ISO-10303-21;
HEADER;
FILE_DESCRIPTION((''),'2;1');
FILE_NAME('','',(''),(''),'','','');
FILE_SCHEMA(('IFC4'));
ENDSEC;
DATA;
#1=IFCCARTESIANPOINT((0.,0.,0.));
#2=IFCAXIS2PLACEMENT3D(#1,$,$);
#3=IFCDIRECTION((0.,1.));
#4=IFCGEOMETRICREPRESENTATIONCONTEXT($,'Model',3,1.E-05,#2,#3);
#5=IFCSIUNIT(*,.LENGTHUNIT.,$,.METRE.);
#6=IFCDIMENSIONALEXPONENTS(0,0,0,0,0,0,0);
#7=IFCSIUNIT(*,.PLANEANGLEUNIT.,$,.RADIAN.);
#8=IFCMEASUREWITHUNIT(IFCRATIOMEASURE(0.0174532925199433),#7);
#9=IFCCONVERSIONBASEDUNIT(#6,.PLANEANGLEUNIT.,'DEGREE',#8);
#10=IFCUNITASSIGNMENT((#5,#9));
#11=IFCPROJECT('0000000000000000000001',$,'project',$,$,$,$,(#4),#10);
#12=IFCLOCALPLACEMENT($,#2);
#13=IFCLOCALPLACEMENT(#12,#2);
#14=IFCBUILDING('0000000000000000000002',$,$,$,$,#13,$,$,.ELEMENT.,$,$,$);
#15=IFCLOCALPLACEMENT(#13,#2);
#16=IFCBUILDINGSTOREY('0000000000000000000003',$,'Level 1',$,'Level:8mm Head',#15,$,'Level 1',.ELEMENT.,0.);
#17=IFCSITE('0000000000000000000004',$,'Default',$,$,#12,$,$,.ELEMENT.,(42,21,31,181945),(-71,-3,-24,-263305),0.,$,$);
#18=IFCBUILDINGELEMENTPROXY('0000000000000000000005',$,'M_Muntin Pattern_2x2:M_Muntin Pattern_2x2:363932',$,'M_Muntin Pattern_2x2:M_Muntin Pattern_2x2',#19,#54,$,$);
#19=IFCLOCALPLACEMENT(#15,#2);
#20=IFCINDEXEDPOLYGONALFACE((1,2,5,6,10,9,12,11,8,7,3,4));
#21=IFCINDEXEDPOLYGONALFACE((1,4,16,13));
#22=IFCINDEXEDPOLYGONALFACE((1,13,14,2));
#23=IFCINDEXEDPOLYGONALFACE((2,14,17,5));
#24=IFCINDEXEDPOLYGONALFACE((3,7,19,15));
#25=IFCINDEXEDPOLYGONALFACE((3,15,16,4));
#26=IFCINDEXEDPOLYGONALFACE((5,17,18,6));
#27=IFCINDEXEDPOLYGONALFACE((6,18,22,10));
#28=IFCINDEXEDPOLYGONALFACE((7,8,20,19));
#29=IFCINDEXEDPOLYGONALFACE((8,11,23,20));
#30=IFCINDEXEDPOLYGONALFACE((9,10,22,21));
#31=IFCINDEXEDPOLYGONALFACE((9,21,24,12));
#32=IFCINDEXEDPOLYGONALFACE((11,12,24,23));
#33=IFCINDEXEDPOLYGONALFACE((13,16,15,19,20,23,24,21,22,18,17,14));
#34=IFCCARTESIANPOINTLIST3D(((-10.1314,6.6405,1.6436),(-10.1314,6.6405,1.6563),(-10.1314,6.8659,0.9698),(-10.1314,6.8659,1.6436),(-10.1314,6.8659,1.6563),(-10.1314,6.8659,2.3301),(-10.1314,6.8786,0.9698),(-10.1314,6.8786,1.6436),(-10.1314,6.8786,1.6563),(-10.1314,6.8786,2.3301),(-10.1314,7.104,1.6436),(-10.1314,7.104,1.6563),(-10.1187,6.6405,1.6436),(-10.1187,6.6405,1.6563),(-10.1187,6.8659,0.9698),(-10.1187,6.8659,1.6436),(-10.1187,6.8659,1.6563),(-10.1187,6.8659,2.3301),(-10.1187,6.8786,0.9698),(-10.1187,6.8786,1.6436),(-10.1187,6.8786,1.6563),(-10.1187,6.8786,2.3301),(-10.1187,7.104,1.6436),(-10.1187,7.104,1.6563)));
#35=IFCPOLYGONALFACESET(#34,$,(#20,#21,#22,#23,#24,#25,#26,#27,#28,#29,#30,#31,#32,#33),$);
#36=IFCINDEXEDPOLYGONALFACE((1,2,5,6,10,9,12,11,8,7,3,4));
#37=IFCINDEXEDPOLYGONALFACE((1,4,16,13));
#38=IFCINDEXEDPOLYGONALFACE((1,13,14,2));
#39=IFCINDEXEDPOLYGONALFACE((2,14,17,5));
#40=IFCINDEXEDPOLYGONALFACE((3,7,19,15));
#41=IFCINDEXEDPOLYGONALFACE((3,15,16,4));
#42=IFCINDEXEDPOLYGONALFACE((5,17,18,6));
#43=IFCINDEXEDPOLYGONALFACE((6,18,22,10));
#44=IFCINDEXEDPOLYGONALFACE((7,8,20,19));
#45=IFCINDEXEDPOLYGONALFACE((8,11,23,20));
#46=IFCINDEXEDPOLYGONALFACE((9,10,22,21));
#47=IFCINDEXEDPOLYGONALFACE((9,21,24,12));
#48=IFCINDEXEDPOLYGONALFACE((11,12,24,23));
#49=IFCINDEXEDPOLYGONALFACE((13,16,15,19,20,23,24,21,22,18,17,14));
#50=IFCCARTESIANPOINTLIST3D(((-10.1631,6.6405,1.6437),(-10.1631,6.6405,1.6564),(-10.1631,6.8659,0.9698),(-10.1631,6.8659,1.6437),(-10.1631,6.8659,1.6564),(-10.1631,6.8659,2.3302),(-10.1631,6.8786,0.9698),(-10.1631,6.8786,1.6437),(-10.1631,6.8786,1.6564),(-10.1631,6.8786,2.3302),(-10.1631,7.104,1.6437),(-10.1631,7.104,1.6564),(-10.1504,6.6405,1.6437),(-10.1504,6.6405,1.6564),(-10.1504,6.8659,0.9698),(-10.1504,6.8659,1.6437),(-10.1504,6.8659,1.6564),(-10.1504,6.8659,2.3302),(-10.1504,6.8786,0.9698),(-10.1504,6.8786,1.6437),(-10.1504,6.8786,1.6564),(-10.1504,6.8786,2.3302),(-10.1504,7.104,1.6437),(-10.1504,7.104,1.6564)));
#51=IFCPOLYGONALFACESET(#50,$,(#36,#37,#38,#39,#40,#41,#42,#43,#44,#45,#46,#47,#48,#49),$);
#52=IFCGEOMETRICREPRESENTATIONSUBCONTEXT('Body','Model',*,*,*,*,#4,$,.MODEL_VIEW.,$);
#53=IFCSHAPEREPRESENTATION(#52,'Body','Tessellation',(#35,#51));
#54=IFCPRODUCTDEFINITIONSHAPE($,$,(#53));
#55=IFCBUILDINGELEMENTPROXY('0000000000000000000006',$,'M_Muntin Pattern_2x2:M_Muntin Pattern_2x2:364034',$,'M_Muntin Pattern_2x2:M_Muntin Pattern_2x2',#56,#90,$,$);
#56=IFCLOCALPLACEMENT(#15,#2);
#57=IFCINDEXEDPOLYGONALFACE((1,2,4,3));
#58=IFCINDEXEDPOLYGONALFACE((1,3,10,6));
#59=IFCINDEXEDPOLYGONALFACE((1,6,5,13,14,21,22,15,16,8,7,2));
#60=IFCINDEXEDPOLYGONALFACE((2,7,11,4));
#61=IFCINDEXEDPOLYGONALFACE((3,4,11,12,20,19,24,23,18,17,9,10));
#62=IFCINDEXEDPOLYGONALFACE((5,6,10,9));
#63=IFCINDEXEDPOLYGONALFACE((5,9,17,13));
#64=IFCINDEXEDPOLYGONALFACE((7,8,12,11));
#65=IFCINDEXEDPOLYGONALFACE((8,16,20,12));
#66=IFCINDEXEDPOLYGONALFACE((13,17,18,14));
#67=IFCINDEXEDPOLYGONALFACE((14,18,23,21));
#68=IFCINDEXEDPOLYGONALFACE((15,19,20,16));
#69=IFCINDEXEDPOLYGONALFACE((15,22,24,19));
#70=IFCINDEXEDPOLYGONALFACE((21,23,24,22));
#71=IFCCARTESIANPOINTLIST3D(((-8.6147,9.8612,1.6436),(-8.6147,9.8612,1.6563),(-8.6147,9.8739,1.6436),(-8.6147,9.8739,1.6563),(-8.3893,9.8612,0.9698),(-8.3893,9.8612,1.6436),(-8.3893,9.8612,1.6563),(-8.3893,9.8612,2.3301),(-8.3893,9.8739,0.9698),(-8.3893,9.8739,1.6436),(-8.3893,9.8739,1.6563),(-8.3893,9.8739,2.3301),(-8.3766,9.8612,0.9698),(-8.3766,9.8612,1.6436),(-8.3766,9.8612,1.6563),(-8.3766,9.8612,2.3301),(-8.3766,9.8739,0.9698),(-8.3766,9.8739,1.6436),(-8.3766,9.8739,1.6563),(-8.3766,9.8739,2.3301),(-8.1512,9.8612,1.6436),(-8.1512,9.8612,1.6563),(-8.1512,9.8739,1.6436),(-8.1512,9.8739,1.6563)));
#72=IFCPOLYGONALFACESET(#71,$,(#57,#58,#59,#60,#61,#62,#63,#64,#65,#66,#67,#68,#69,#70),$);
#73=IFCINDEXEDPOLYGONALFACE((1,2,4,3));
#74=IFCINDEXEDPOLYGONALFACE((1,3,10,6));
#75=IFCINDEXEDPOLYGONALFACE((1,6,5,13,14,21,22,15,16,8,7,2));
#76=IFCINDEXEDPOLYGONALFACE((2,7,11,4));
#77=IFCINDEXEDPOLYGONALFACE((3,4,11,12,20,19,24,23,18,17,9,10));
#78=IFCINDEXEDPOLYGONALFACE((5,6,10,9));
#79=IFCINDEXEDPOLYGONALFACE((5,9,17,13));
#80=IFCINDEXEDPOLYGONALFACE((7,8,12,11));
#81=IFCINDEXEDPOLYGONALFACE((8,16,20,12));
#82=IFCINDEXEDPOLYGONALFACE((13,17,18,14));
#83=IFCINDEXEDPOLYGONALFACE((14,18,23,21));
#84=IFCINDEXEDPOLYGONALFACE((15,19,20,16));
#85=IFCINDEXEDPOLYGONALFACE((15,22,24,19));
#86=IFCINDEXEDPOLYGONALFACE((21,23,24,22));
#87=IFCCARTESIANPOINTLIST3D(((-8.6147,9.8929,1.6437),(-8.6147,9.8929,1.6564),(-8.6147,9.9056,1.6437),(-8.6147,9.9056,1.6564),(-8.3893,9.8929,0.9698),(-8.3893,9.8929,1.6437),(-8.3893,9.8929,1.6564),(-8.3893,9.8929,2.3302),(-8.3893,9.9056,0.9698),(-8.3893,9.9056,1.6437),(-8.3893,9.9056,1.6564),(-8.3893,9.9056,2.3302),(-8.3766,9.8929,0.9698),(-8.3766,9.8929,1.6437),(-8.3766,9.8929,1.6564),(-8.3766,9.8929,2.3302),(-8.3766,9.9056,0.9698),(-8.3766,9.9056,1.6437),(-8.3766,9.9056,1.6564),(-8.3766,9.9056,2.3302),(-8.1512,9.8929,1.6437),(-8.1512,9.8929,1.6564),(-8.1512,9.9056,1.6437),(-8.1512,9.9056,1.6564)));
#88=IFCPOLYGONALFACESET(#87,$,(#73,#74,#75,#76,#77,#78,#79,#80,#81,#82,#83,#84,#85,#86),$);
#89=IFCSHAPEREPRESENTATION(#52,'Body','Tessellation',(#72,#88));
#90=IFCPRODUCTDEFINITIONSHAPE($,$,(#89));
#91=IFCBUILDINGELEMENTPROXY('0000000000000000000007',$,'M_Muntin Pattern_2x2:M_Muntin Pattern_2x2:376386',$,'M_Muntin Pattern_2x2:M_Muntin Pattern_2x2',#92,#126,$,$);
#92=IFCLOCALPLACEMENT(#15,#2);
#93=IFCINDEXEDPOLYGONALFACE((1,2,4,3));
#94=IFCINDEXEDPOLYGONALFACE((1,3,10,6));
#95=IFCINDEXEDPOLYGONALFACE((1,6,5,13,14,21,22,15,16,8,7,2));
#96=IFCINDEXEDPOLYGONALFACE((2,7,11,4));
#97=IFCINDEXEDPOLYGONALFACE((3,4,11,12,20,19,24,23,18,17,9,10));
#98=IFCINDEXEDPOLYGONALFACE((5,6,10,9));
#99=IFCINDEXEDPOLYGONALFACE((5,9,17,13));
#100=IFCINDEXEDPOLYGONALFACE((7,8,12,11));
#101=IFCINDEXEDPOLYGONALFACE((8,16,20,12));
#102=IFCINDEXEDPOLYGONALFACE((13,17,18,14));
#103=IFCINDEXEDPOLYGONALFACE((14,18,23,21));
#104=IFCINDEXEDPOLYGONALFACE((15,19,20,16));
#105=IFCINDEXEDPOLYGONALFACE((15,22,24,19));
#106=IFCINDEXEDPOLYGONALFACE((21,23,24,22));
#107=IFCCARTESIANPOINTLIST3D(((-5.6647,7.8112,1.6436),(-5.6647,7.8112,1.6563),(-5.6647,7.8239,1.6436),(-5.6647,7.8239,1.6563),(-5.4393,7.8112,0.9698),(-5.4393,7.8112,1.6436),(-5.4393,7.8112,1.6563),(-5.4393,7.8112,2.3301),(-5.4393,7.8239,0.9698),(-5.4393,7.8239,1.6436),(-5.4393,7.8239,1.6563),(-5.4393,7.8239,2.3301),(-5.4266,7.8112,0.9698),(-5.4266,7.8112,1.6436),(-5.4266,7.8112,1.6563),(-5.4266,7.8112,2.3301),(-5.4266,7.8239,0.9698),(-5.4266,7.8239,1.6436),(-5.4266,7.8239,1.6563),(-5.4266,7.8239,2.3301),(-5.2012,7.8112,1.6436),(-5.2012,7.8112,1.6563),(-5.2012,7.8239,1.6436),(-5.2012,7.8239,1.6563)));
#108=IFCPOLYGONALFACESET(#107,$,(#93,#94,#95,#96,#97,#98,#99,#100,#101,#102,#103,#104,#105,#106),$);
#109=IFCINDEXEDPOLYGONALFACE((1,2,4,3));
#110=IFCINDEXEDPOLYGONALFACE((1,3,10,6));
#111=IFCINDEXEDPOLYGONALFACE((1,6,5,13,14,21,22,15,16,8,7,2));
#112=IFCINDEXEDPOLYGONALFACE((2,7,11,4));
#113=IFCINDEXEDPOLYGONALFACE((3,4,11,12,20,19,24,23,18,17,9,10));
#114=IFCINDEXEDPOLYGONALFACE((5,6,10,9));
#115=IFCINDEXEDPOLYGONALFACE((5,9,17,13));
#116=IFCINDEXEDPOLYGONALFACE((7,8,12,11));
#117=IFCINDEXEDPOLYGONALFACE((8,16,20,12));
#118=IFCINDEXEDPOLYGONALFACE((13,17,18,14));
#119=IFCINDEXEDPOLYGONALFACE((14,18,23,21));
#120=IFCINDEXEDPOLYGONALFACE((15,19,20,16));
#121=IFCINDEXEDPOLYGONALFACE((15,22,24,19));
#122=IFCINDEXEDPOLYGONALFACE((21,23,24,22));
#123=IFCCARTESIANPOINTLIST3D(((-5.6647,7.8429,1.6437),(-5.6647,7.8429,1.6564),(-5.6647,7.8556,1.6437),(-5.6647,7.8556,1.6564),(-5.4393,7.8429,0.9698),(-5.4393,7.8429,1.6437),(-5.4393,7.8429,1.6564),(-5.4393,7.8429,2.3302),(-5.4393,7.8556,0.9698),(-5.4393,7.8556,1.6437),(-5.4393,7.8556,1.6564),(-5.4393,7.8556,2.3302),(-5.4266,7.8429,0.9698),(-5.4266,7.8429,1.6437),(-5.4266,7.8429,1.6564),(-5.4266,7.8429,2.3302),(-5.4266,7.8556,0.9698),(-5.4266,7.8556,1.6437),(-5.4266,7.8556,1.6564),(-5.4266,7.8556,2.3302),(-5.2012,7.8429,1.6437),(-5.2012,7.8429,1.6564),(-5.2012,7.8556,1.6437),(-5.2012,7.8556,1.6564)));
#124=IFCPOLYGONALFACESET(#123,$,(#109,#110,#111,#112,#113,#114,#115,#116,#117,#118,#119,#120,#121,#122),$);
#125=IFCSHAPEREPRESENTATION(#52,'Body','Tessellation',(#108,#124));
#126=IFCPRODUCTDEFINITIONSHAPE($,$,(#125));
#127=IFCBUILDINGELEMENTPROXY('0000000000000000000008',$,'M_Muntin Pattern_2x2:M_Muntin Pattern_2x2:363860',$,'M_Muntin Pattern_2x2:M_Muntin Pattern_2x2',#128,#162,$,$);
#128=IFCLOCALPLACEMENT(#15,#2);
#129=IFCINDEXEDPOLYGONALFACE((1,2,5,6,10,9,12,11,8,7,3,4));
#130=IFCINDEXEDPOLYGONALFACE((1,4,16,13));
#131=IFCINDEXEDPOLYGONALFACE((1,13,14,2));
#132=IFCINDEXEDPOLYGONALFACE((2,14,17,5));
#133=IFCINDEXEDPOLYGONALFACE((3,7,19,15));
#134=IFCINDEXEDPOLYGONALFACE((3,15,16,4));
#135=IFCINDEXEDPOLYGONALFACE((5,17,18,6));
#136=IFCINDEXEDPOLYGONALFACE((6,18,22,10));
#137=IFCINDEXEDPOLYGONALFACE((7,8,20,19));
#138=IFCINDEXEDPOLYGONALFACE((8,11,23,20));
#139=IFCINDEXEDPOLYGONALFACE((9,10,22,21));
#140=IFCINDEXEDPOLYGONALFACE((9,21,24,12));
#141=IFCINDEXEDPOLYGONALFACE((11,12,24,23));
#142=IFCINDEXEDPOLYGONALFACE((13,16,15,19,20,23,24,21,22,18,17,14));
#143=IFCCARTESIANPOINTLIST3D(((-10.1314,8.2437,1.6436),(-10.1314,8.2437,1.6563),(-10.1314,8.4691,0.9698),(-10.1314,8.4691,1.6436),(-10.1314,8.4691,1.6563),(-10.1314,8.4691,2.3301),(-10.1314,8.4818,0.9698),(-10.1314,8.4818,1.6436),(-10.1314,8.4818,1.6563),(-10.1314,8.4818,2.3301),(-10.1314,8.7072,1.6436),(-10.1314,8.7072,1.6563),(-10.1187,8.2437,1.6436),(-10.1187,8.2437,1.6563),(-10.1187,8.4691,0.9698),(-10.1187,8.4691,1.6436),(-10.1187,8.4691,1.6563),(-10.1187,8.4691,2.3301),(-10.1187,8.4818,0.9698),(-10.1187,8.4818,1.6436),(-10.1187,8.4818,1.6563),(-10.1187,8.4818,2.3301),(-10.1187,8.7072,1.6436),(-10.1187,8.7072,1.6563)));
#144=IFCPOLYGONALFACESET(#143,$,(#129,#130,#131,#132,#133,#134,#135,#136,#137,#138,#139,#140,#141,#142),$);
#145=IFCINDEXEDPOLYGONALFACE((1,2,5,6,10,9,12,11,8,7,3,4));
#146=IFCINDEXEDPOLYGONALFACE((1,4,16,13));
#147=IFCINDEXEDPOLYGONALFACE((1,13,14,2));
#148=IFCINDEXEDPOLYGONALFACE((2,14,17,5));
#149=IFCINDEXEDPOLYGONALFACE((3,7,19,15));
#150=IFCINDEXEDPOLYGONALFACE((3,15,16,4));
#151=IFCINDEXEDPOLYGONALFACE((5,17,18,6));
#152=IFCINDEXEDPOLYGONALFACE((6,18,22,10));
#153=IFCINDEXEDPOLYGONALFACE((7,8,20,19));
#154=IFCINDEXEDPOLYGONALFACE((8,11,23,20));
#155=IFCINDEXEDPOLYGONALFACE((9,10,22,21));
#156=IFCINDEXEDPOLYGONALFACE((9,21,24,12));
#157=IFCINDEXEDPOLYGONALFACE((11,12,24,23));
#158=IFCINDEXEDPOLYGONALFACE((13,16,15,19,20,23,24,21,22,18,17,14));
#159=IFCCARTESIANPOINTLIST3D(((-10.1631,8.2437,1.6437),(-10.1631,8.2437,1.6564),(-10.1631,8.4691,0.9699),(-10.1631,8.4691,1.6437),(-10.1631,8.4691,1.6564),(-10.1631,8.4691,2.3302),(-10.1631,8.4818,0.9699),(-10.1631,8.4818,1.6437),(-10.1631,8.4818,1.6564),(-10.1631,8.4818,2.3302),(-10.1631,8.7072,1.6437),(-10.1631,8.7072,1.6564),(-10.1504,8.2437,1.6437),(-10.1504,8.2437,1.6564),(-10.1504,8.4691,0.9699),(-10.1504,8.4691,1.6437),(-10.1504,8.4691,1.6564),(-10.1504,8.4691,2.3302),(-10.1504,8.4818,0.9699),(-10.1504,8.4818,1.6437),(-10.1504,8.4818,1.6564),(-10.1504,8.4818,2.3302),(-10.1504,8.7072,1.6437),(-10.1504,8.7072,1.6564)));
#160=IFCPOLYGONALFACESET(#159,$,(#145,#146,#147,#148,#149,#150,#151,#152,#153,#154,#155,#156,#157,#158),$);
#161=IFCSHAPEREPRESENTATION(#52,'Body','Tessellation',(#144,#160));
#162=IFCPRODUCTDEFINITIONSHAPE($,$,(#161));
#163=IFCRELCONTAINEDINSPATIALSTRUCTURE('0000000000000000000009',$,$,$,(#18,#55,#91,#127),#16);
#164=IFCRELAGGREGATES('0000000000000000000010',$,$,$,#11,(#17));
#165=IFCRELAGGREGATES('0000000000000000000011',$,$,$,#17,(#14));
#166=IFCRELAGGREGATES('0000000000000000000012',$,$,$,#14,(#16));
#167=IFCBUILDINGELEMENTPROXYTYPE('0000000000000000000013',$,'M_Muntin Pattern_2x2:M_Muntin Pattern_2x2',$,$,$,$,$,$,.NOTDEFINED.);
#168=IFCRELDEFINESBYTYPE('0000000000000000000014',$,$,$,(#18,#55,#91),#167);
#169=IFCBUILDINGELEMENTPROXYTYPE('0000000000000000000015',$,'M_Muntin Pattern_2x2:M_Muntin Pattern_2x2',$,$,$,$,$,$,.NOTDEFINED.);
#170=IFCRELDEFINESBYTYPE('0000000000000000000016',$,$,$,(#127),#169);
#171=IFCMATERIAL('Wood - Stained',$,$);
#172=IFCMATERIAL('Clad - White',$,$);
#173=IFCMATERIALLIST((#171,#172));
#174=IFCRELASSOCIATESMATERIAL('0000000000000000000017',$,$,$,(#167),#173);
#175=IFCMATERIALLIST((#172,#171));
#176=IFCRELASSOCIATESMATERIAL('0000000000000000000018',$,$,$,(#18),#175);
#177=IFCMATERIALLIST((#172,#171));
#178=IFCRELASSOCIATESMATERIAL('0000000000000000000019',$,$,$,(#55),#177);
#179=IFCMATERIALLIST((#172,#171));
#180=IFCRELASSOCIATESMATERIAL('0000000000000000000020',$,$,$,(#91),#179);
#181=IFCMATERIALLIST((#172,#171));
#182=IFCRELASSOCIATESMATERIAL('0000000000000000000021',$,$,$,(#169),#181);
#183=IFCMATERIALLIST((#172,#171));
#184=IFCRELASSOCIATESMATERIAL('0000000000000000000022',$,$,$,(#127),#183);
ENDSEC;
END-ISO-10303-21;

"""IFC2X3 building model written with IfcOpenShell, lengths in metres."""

from ifc_helpers import new_model, entity, si_unit, converted_unit, direction, frame, origin, place, context, subcontext, project, spatial, polyline, outline, extrude, source, transform, mapped, material, material_list, type_object, type_shapes, element, save


model = new_model("IFC2X3")

# Units and contexts
model_context = context("Model", 3, precision=1e-05, world=origin(), true_north=direction((0.0, 1.0)))
body_context = subcontext(model_context, "Body", "Model", "MODEL_VIEW")
ifc_project = project(units=[si_unit("LENGTHUNIT", "METRE"), converted_unit("PLANEANGLEUNIT", "DEGREE", entity("IfcRatioMeasure", 0.0174532925199433), si_unit("PLANEANGLEUNIT", "RADIAN"), dimensions=[0, 0, 0, 0, 0, 0, 0])], contexts=[model_context])

# Site, building, storey
site_placement = place(None, origin())
site = spatial("IfcSite", under=ifc_project, at=site_placement, Name="Default", CompositionType="ELEMENT", RefLatitude=(42, 21, 31, 181945), RefLongitude=(-71, -3, -24, -263305), RefElevation=0.0)
building_placement = place(site_placement, origin())
building = spatial("IfcBuilding", under=site, at=building_placement, CompositionType="ELEMENT")
storey_placement = place(building_placement, origin())
storey = spatial("IfcBuildingStorey", under=building, at=storey_placement, Name="Level 1", ObjectType="Level:8mm Head", LongName="Level 1", CompositionType="ELEMENT", Elevation=0.0)

# Building element proxies
ifc_material_1 = material(Name="Clad - White")
ifc_material_2 = material(Name="Wood - Stained")
ifc_material_list_1 = material_list([ifc_material_2, ifc_material_1])
building_element_proxy_type_1 = type_object("IfcBuildingElementProxyType", Name="M_Muntin Pattern_2x2:M_Muntin Pattern_2x2", PredefinedType="NOTDEFINED", material=ifc_material_list_1)
shared_shape_1 = source(origin(), body_context, "Body", "SweptSolid", [
    extrude(outline(polyline([(0.0064, -0.0064), (0.6801, -0.0064), (0.6801, 0.0063), (0.0064, 0.0063), (0.0064, 0.2317), (-0.0063, 0.2317), (-0.0063, 0.0063), (-0.6802, 0.0063), (-0.6802, -0.0064), (-0.0063, -0.0064), (-0.0063, -0.2317), (0.0064, -0.2317), (0.0064, -0.0064)])), frame((0.0, 0.0095, 0.6801), z_axis=(0.0, 1.0, 0.0), x_axis=(0.0, 0.0, 1.0)), (0.0, 0.0, 1.0), 0.0127),
    extrude(outline(polyline([(0.0064, -0.0064), (0.6802, -0.0064), (0.6802, 0.0063), (0.0064, 0.0063), (0.0064, 0.2317), (-0.0063, 0.2317), (-0.0063, 0.0063), (-0.6802, 0.0063), (-0.6802, -0.0064), (-0.0063, -0.0064), (-0.0063, -0.2317), (0.0064, -0.2317), (0.0064, -0.0064)])), frame((0.0, -0.0222, 0.6802), z_axis=(0.0, 1.0, 0.0), x_axis=(0.0, 0.0, 1.0)), (0.0, 0.0, 1.0), 0.0127),
])
type_shapes(building_element_proxy_type_1, [shared_shape_1])
ifc_material_list_2 = material_list([ifc_material_1, ifc_material_2])
proxy_1_placement = place(storey_placement, frame((-10.1409, 6.8723, 0.9698), z_axis=(0.0, 0.0, 1.0), x_axis=(0.0, -1.0, 0.0)))
element("IfcBuildingElementProxy", 1, at=proxy_1_placement, inside=storey, type_object=building_element_proxy_type_1, material=ifc_material_list_2, Name="M_Muntin Pattern_2x2:M_Muntin Pattern_2x2:363932", ObjectType="M_Muntin Pattern_2x2:M_Muntin Pattern_2x2", context=body_context, shape_type="MappedRepresentation", body=[
    mapped(shared_shape_1, transform((0.0, 0.0, 0.0), scale=1.0)),
])
ifc_material_list_3 = material_list([ifc_material_1, ifc_material_2])
proxy_2_placement = place(storey_placement, frame((-8.383, 9.8834, 0.9698), z_axis=(0.0, 0.0, 1.0), x_axis=(-1.0, 0.0, 0.0)))
element("IfcBuildingElementProxy", 2, at=proxy_2_placement, inside=storey, type_object=building_element_proxy_type_1, material=ifc_material_list_3, Name="M_Muntin Pattern_2x2:M_Muntin Pattern_2x2:364034", ObjectType="M_Muntin Pattern_2x2:M_Muntin Pattern_2x2", context=body_context, shape_type="MappedRepresentation", body=[
    mapped(shared_shape_1, transform((0.0, 0.0, 0.0), scale=1.0)),
])
ifc_material_list_4 = material_list([ifc_material_1, ifc_material_2])
proxy_3_placement = place(storey_placement, frame((-5.433, 7.8334, 0.9698), z_axis=(0.0, 0.0, 1.0), x_axis=(-1.0, 0.0, 0.0)))
element("IfcBuildingElementProxy", 3, at=proxy_3_placement, inside=storey, type_object=building_element_proxy_type_1, material=ifc_material_list_4, Name="M_Muntin Pattern_2x2:M_Muntin Pattern_2x2:376386", ObjectType="M_Muntin Pattern_2x2:M_Muntin Pattern_2x2", context=body_context, shape_type="MappedRepresentation", body=[
    mapped(shared_shape_1, transform((0.0, 0.0, 0.0), scale=1.0)),
])
ifc_material_list_5 = material_list([ifc_material_1, ifc_material_2])
ifc_material_list_6 = material_list([ifc_material_1, ifc_material_2])
building_element_proxy_type_2 = type_object("IfcBuildingElementProxyType", Name="M_Muntin Pattern_2x2:M_Muntin Pattern_2x2", PredefinedType="NOTDEFINED", material=ifc_material_list_6)
shared_shape_2 = source(origin(), body_context, "Body", "SweptSolid", [
    extrude(outline(polyline([(0.0064, -0.0064), (0.6801, -0.0064), (0.6801, 0.0063), (0.0064, 0.0063), (0.0064, 0.2317), (-0.0063, 0.2317), (-0.0063, 0.0063), (-0.6802, 0.0063), (-0.6802, -0.0064), (-0.0063, -0.0064), (-0.0063, -0.2317), (0.0064, -0.2317), (0.0064, -0.0064)])), frame((0.0, -0.0222, 0.6801), z_axis=(0.0, 1.0, 0.0), x_axis=(0.0, 0.0, 1.0)), (0.0, 0.0, 1.0), 0.0127),
    extrude(outline(polyline([(0.0064, -0.0064), (0.6802, -0.0064), (0.6802, 0.0063), (0.0064, 0.0063), (0.0064, 0.2317), (-0.0063, 0.2317), (-0.0063, 0.0063), (-0.6802, 0.0063), (-0.6802, -0.0064), (-0.0063, -0.0064), (-0.0063, -0.2317), (0.0064, -0.2317), (0.0064, -0.0064)])), frame((0.0, 0.0095, 0.6802), z_axis=(0.0, 1.0, 0.0), x_axis=(0.0, 0.0, 1.0)), (0.0, 0.0, 1.0), 0.0127),
])
type_shapes(building_element_proxy_type_2, [shared_shape_2])
proxy_4_placement = place(storey_placement, frame((-10.1409, 8.4754, 0.9699), z_axis=(0.0, 0.0, 1.0), x_axis=(0.0, 1.0, 0.0)))
element("IfcBuildingElementProxy", 4, at=proxy_4_placement, inside=storey, type_object=building_element_proxy_type_2, material=ifc_material_list_5, Name="M_Muntin Pattern_2x2:M_Muntin Pattern_2x2:363860", ObjectType="M_Muntin Pattern_2x2:M_Muntin Pattern_2x2", context=body_context, shape_type="MappedRepresentation", body=[
    mapped(shared_shape_2, transform((0.0, 0.0, 0.0), scale=1.0)),
])

save(model, "model.ifc")
